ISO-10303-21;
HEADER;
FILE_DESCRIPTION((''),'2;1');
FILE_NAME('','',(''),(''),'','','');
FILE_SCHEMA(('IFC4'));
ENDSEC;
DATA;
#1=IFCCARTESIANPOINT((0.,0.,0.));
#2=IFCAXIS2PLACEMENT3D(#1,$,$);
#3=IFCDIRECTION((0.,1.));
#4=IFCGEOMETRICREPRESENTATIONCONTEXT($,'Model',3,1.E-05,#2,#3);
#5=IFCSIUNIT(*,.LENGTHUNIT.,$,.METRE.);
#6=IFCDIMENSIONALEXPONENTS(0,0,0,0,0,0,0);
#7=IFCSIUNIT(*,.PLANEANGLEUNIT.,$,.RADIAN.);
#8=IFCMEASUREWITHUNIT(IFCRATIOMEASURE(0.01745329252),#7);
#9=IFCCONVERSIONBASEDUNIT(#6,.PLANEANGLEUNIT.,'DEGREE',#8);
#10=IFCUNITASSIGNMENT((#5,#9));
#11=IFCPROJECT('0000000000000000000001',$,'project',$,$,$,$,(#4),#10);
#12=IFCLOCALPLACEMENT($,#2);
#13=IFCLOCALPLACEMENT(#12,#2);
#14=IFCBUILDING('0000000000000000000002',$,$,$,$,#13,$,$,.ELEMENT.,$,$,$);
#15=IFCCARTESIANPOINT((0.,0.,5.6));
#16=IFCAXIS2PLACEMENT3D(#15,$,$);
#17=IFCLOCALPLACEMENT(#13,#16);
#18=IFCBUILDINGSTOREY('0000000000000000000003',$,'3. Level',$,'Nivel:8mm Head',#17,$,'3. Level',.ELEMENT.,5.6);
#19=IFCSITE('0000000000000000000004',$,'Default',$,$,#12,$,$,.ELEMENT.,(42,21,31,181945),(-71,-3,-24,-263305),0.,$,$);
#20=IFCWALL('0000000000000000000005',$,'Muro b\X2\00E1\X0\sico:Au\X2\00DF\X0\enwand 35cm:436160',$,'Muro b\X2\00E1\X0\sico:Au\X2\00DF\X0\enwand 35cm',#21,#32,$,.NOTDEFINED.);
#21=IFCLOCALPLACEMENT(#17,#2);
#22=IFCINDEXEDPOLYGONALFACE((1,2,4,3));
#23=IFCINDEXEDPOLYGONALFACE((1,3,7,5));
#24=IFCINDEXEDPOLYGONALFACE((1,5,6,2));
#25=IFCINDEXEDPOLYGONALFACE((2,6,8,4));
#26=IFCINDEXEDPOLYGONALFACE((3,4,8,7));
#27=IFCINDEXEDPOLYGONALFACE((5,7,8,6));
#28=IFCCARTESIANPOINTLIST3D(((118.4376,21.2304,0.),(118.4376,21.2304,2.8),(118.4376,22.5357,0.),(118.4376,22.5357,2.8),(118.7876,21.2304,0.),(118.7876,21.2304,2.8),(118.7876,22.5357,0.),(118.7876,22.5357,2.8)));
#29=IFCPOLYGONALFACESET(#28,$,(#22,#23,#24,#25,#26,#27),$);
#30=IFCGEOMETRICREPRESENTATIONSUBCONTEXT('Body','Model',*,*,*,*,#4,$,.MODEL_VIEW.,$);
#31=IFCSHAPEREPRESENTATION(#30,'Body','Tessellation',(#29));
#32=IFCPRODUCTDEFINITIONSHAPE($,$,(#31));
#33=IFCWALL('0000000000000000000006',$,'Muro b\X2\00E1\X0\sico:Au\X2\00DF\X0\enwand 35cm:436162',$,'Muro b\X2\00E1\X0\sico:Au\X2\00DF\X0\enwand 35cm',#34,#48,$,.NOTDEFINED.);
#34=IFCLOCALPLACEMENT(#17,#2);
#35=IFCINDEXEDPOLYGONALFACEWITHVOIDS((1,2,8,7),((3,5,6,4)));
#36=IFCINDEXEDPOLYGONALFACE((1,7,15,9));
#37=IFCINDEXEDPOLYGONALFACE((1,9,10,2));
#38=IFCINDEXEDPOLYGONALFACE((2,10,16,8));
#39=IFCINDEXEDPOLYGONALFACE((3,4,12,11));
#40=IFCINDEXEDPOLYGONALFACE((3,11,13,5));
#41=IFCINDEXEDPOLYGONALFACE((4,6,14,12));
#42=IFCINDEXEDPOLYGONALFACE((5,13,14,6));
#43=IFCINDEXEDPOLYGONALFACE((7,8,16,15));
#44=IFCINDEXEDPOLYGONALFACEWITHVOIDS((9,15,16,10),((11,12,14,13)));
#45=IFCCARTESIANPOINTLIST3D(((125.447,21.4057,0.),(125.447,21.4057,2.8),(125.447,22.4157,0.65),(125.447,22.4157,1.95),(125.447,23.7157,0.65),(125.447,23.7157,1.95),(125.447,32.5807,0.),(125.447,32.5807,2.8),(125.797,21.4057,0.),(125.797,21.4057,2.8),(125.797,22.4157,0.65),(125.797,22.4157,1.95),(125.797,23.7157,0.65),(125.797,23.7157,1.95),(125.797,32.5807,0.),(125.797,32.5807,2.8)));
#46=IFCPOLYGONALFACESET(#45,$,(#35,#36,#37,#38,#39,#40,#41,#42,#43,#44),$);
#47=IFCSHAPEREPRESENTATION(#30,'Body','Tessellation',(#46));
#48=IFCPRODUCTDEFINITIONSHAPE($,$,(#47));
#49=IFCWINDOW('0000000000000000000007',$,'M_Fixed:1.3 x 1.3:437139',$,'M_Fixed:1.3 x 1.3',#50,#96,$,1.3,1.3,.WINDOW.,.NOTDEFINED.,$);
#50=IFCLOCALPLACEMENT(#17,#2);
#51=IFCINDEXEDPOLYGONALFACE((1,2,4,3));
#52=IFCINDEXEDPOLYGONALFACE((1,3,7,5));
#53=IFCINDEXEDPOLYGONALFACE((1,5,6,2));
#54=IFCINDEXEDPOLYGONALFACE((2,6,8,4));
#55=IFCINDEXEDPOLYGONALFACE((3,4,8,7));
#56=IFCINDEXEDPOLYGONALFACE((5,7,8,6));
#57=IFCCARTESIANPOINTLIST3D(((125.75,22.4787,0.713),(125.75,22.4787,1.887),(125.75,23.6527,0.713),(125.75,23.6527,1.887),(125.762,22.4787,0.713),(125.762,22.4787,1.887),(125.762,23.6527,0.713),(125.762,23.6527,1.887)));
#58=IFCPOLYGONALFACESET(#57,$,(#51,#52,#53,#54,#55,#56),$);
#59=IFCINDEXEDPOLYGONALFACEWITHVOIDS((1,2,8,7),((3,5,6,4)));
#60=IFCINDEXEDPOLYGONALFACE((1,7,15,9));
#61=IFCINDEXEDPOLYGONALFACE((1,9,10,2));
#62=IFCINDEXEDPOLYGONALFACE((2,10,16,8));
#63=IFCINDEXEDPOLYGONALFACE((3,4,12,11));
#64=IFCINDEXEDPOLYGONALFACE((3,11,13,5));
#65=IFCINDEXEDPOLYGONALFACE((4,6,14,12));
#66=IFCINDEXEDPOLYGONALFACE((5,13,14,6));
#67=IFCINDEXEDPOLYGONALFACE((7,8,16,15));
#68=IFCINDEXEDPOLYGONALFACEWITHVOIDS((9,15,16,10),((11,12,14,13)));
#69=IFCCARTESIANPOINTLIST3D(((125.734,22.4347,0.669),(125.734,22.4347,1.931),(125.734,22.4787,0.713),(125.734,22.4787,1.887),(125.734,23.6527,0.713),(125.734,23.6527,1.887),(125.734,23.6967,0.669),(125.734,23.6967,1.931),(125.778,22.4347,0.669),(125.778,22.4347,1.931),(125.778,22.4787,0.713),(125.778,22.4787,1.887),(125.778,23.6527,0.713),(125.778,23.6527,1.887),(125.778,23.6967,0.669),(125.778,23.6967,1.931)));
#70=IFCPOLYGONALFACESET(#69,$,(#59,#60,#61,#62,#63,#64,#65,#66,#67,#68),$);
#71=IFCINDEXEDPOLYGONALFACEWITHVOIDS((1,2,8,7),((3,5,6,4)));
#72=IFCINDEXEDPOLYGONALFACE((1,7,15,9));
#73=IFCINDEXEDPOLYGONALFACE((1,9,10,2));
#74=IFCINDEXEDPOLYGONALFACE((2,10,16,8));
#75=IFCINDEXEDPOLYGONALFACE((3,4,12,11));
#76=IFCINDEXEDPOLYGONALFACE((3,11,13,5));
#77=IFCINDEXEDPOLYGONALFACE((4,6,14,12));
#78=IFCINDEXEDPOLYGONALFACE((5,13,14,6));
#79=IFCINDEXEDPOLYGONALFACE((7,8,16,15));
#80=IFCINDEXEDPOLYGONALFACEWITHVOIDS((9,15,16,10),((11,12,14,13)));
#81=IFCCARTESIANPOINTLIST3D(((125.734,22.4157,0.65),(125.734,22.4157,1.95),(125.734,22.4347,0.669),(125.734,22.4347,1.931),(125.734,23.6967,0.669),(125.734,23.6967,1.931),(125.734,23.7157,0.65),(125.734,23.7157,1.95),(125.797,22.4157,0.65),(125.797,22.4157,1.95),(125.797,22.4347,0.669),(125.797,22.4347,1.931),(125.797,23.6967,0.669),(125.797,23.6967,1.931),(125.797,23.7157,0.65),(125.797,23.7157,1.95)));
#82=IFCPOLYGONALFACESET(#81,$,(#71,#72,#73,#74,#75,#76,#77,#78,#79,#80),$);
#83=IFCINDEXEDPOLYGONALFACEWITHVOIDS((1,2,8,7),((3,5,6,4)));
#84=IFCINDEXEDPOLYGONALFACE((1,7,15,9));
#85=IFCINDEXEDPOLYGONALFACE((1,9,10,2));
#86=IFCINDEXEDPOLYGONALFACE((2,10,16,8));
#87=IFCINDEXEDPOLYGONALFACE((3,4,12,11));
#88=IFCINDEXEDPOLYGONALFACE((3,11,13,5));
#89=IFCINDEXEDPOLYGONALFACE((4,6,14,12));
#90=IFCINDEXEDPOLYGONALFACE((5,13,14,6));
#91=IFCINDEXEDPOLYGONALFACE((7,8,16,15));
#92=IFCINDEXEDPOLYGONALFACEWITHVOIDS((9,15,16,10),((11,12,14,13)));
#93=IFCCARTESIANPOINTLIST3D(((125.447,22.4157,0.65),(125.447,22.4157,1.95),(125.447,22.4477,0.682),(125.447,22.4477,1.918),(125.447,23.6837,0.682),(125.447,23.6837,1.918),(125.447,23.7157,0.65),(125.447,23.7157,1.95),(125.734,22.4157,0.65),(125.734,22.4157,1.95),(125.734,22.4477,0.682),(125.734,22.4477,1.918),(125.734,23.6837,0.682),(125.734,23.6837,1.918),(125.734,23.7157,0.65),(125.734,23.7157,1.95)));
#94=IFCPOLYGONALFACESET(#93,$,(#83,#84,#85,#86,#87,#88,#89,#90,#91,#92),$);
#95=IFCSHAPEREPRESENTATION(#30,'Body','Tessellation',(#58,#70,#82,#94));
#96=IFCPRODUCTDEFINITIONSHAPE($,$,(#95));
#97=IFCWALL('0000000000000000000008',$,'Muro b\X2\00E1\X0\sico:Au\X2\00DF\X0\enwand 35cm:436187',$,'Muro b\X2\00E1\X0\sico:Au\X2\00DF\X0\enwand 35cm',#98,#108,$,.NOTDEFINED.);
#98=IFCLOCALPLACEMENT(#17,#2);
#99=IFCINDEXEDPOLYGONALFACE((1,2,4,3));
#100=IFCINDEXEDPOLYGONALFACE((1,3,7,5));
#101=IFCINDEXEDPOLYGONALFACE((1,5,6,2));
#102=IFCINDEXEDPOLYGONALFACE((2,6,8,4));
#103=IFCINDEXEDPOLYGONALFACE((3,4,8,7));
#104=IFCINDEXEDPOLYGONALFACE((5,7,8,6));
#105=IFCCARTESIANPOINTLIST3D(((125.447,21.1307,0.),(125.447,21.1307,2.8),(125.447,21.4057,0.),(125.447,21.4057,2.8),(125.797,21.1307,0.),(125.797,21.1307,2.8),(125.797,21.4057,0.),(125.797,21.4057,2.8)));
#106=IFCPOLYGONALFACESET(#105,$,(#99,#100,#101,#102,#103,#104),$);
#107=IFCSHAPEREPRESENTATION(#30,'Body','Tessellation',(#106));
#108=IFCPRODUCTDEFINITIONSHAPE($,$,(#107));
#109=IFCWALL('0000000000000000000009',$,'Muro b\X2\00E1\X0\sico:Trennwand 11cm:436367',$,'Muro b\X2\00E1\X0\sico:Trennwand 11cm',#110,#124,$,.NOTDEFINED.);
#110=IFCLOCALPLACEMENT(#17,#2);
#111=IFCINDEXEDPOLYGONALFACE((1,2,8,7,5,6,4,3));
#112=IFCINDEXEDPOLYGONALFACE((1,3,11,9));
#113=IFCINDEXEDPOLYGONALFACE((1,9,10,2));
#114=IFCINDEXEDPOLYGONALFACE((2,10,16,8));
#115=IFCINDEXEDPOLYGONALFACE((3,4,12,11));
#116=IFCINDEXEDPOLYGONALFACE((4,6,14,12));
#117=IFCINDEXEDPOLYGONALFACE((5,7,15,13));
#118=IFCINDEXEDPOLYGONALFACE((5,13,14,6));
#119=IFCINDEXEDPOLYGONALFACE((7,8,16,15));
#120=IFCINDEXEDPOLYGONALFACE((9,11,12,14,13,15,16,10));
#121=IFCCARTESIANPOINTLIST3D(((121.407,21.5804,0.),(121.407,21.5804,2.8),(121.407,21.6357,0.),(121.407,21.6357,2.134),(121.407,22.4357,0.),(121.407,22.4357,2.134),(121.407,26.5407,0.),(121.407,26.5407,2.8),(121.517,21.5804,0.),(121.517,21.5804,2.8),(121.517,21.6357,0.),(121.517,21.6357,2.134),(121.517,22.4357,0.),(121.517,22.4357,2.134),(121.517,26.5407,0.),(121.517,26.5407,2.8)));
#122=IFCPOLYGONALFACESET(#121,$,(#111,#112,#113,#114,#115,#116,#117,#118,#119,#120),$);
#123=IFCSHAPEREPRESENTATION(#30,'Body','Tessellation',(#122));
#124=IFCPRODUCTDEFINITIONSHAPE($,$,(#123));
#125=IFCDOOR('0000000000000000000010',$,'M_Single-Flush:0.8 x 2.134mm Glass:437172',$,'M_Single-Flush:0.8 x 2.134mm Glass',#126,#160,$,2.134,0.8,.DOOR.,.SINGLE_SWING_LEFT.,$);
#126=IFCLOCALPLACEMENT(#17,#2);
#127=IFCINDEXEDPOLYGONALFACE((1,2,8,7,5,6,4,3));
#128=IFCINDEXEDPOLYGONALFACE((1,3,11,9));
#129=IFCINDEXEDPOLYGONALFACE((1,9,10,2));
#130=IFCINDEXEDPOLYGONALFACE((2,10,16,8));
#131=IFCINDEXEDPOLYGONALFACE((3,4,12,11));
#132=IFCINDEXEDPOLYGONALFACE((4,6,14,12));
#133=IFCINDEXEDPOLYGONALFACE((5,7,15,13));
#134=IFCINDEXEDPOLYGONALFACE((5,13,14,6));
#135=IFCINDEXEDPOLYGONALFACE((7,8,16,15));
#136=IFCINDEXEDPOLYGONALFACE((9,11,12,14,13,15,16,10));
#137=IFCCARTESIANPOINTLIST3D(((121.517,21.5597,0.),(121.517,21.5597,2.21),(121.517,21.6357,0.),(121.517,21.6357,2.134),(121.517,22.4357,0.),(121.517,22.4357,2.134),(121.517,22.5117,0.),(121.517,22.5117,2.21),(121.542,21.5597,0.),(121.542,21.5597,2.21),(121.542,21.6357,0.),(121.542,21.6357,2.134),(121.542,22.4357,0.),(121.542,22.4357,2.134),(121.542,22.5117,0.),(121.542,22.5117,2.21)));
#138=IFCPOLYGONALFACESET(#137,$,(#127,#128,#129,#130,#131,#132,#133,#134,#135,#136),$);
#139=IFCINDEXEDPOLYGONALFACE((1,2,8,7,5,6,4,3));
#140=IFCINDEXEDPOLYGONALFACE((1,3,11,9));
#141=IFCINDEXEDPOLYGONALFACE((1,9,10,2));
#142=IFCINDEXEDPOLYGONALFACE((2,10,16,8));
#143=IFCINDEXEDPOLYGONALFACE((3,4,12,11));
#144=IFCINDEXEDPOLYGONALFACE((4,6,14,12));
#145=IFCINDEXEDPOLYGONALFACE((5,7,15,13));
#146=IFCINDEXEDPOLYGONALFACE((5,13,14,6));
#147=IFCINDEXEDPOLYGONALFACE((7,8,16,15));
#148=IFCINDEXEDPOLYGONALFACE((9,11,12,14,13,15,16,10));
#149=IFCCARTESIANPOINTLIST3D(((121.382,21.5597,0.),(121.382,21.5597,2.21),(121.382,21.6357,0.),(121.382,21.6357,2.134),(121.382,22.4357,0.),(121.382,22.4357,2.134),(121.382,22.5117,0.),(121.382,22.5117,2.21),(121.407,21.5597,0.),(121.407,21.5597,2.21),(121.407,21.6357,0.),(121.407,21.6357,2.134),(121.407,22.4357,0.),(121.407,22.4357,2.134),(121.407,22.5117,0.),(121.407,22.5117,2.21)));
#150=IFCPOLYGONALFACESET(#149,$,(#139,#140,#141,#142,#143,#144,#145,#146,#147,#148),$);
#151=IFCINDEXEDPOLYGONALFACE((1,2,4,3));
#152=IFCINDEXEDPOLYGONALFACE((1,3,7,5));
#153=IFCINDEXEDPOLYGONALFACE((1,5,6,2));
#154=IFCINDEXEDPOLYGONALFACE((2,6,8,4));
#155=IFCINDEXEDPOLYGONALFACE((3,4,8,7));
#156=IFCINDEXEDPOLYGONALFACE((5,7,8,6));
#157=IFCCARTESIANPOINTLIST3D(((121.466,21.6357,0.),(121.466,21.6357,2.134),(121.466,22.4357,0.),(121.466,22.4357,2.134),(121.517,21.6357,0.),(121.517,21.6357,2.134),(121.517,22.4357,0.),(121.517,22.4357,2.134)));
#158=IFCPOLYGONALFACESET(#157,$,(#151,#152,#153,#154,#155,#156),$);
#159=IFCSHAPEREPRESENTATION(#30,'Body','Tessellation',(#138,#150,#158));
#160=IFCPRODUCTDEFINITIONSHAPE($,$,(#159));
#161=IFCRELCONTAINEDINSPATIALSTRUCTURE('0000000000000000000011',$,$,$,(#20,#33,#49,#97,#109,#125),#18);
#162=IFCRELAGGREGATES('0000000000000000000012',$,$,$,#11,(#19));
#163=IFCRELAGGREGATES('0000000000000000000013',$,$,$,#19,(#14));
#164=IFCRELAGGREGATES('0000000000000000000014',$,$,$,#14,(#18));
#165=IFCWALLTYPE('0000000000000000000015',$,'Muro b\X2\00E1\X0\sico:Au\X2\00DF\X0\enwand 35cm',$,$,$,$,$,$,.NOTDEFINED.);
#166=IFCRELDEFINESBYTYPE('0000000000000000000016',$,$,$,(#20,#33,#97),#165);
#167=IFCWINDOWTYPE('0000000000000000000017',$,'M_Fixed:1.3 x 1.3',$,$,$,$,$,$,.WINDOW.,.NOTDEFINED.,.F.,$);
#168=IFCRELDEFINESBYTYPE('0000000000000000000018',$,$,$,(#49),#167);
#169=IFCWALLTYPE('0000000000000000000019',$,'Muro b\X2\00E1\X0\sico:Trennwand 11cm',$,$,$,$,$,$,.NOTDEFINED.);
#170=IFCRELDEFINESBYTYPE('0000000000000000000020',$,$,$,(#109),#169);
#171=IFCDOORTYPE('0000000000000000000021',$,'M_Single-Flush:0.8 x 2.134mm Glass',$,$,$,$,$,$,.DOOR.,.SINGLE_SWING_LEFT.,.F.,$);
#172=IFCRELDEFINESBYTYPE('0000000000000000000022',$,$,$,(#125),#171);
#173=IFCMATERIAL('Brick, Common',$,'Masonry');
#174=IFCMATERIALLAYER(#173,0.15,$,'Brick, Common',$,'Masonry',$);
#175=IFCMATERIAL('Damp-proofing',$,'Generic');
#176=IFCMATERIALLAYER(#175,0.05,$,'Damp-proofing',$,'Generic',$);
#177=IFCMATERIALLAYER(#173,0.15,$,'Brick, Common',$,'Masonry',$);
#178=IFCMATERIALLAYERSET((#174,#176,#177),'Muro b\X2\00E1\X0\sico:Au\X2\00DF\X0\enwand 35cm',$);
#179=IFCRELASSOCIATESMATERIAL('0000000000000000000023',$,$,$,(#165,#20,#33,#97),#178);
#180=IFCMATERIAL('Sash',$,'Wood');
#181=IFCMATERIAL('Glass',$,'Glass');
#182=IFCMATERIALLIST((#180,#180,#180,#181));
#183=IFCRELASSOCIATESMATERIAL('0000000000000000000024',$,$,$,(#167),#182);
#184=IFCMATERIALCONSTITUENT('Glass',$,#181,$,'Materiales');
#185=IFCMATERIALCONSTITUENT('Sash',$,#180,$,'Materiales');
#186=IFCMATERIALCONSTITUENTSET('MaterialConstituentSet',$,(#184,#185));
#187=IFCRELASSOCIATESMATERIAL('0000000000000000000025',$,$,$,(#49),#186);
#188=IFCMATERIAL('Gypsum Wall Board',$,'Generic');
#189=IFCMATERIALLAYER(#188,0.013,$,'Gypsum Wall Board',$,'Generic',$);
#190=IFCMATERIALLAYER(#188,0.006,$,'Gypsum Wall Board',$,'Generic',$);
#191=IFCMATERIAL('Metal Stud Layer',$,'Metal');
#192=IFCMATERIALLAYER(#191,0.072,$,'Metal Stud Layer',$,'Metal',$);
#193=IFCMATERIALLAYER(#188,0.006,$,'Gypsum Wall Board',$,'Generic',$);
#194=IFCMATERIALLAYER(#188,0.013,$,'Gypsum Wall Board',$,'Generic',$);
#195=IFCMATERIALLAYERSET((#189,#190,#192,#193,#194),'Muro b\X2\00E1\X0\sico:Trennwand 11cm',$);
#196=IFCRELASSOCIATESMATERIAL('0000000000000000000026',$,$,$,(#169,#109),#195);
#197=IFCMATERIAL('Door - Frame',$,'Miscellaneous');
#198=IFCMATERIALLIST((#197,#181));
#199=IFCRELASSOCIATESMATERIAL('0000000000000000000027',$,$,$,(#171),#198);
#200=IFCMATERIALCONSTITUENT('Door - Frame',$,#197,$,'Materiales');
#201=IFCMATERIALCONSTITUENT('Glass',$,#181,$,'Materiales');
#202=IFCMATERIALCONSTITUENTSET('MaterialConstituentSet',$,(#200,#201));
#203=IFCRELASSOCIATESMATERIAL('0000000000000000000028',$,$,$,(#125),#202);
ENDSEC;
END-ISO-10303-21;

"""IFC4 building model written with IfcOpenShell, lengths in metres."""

from ifc_helpers import new_model, entity, si_unit, converted_unit, direction, frame, frame_2d, origin, origin_2d_with_axis, place, context, subcontext, project, spatial, polyline, rectangle, outline, extrude, source, transform, mapped, material, material_list, layer, layer_set, layer_usage, constituent, constituent_set, type_object, type_shapes, element, fill, save


model = new_model("IFC4")

# Units and contexts
model_context = context("Model", 3, precision=1e-05, world=origin(), true_north=direction((0.0, 1.0)))
body_context = subcontext(model_context, "Body", "Model", "MODEL_VIEW")
ifc_project = project(units=[si_unit("LENGTHUNIT", "METRE"), converted_unit("PLANEANGLEUNIT", "DEGREE", entity("IfcRatioMeasure", 0.01745329252), si_unit("PLANEANGLEUNIT", "RADIAN"), dimensions=[0, 0, 0, 0, 0, 0, 0])], contexts=[model_context])

# Site, building, storey
site_placement = place(None, origin())
site = spatial("IfcSite", under=ifc_project, at=site_placement, Name="Default", CompositionType="ELEMENT", RefLatitude=(42, 21, 31, 181945), RefLongitude=(-71, -3, -24, -263305), RefElevation=0.0)
building_placement = place(site_placement, origin())
building = spatial("IfcBuilding", under=site, at=building_placement, CompositionType="ELEMENT")
storey_placement = place(building_placement, frame((0.0, 0.0, 5.6)))
storey = spatial("IfcBuildingStorey", under=building, at=storey_placement, Name="3. Level", ObjectType="Nivel:8mm Head", LongName="3. Level", CompositionType="ELEMENT", Elevation=5.6)

# Wall
ifc_material_1 = material(Name="Brick, Common", Category="Masonry")
ifc_layer_1 = layer(ifc_material_1, 0.15, Name="Brick, Common", Category="Masonry")
ifc_material_2 = material(Name="Damp-proofing", Category="Generic")
ifc_layer_2 = layer(ifc_material_2, 0.05, Name="Damp-proofing", Category="Generic")
ifc_layer_3 = layer(ifc_material_1, 0.15, Name="Brick, Common", Category="Masonry")
ifc_layer_set_1 = layer_set([ifc_layer_1, ifc_layer_2, ifc_layer_3], Name="Muro básico:Außenwand 35cm")
ifc_layer_usage_1 = layer_usage(ifc_layer_set_1, "AXIS2", "NEGATIVE", 0.175)
wall_type_1 = type_object("IfcWallType", Name="Muro básico:Außenwand 35cm", PredefinedType="NOTDEFINED", material=ifc_layer_set_1)
wall_1_placement = place(storey_placement, frame((118.6126, 21.2304, 0.0), z_axis=(0.0, 0.0, 1.0), x_axis=(0.0, 1.0, 0.0)))
element("IfcWall", 1, at=wall_1_placement, inside=storey, type_object=wall_type_1, material=ifc_layer_usage_1, Name="Muro básico:Außenwand 35cm:436160", ObjectType="Muro básico:Außenwand 35cm", PredefinedType="NOTDEFINED", context=body_context, shape_type="SweptSolid", body=[
    extrude(rectangle(XDim=1.3053, YDim=0.35, at=frame_2d((0.6527, 0.0), x_axis=(-1.0, 0.0))), origin(), (0.0, 0.0, 1.0), 2.8),
])

# Wall, opening, window
ifc_layer_usage_2 = layer_usage(ifc_layer_set_1, "AXIS2", "NEGATIVE", 0.175)
wall_2_placement = place(storey_placement, frame((125.622, 21.4057, 0.0), z_axis=(0.0, 0.0, 1.0), x_axis=(0.0, 1.0, 0.0)))
wall_2 = element("IfcWall", 2, at=wall_2_placement, inside=storey, type_object=wall_type_1, material=ifc_layer_usage_2, Name="Muro básico:Außenwand 35cm:436162", ObjectType="Muro básico:Außenwand 35cm", PredefinedType="NOTDEFINED", context=body_context, shape_type="SweptSolid", body=[
    extrude(rectangle(XDim=11.175, YDim=0.35, at=frame_2d((5.5875, 0.0), x_axis=(-1.0, 0.0))), origin(), (0.0, 0.0, 1.0), 2.8),
])
opening_1_placement = place(wall_2_placement, frame((2.31, 0.175, 0.65)))
opening_1 = element("IfcOpeningElement", 3, at=opening_1_placement, cuts=wall_2, ObjectType="Opening", PredefinedType="OPENING", context=body_context, shape_type="SweptSolid", body=[
    extrude(rectangle(XDim=1.3, YDim=1.3, at=frame_2d((0.65, 0.65), x_axis=(1.0, 0.0))), frame((0.0, 0.0, 0.0), z_axis=(0.0, -1.0, 0.0), x_axis=(0.0, 0.0, 1.0)), (0.0, 0.0, 1.0), 0.35),
])
ifc_material_3 = material(Name="Glass", Category="Glass")
ifc_constituent_1 = constituent(ifc_material_3, Name="Glass", Category="Materiales")
ifc_material_4 = material(Name="Sash", Category="Wood")
ifc_constituent_2 = constituent(ifc_material_4, Name="Sash", Category="Materiales")
ifc_constituent_set_1 = constituent_set(constituents=[ifc_constituent_1, ifc_constituent_2], Name="MaterialConstituentSet")
ifc_material_list_1 = material_list([ifc_material_4, ifc_material_4, ifc_material_4, ifc_material_3])
window_type = type_object("IfcWindowType", Name="M_Fixed:1.3 x 1.3", ParameterTakesPrecedence=False, PartitioningType="NOTDEFINED", PredefinedType="WINDOW", material=ifc_material_list_1)
shared_shape_1 = source(origin(), body_context, "Body", "SweptSolid", [
    extrude(rectangle(XDim=0.012, YDim=1.174, at=origin_2d_with_axis()), frame((0.65, 0.309, 0.063), z_axis=(0.0, 0.0, 1.0), x_axis=(0.0, -1.0, 0.0)), (0.0, 0.0, 1.0), 1.174),
    extrude(outline(polyline([(-0.631, -0.631), (0.631, -0.631), (0.631, 0.631), (-0.631, 0.631), (-0.631, -0.631)]), holes=[polyline([(-0.587, -0.587), (-0.587, 0.587), (0.587, 0.587), (0.587, -0.587), (-0.587, -0.587)])]), frame((0.65, 0.287, 0.65), z_axis=(0.0, 1.0, 0.0), x_axis=(1.0, 0.0, 0.0)), (0.0, 0.0, 1.0), 0.044),
    extrude(outline(polyline([(-0.65, -0.65), (0.65, -0.65), (0.65, 0.65), (-0.65, 0.65), (-0.65, -0.65)]), holes=[polyline([(-0.631, -0.631), (-0.631, 0.631), (0.631, 0.631), (0.631, -0.631), (-0.631, -0.631)])]), frame((0.65, 0.287, 0.65), z_axis=(0.0, 1.0, 0.0), x_axis=(1.0, 0.0, 0.0)), (0.0, 0.0, 1.0), 0.063),
    extrude(outline(polyline([(-0.65, -0.65), (0.65, -0.65), (0.65, 0.65), (-0.65, 0.65), (-0.65, -0.65)]), holes=[polyline([(-0.618, -0.618), (-0.618, 0.618), (0.618, 0.618), (0.618, -0.618), (-0.618, -0.618)])]), frame((0.65, 0.0, 0.65), z_axis=(0.0, 1.0, 0.0), x_axis=(1.0, 0.0, 0.0)), (0.0, 0.0, 1.0), 0.287),
])
type_shapes(window_type, [shared_shape_1])
window_placement = place(opening_1_placement, frame((0.0, 0.0, 0.0), z_axis=(0.0, 0.0, 1.0), x_axis=(-1.0, 0.0, 0.0)))
window = element("IfcWindow", 4, at=window_placement, inside=storey, type_object=window_type, material=ifc_constituent_set_1, Name="M_Fixed:1.3 x 1.3:437139", ObjectType="M_Fixed:1.3 x 1.3", OverallHeight=1.3, OverallWidth=1.3, PartitioningType="NOTDEFINED", PredefinedType="WINDOW", context=body_context, shape_type="MappedRepresentation", body=[
    mapped(shared_shape_1, transform((0.0, 0.0, 0.0), scale=1.0)),
])
fill(opening_1, window)

# Wall
ifc_layer_usage_3 = layer_usage(ifc_layer_set_1, "AXIS2", "NEGATIVE", 0.175)
wall_3_placement = place(storey_placement, frame((125.622, 21.4057, 0.0), z_axis=(0.0, 0.0, 1.0), x_axis=(0.0, -1.0, 0.0)))
element("IfcWall", 5, at=wall_3_placement, inside=storey, type_object=wall_type_1, material=ifc_layer_usage_3, Name="Muro básico:Außenwand 35cm:436187", ObjectType="Muro básico:Außenwand 35cm", PredefinedType="NOTDEFINED", context=body_context, shape_type="SweptSolid", body=[
    extrude(rectangle(XDim=0.275, YDim=0.35, at=frame_2d((0.1375, 0.0), x_axis=(-1.0, 0.0))), origin(), (0.0, 0.0, 1.0), 2.8),
])

# Wall, opening, door
ifc_material_5 = material(Name="Gypsum Wall Board", Category="Generic")
ifc_layer_4 = layer(ifc_material_5, 0.013, Name="Gypsum Wall Board", Category="Generic")
ifc_layer_5 = layer(ifc_material_5, 0.006, Name="Gypsum Wall Board", Category="Generic")
ifc_material_6 = material(Name="Metal Stud Layer", Category="Metal")
ifc_layer_6 = layer(ifc_material_6, 0.072, Name="Metal Stud Layer", Category="Metal")
ifc_layer_7 = layer(ifc_material_5, 0.006, Name="Gypsum Wall Board", Category="Generic")
ifc_layer_8 = layer(ifc_material_5, 0.013, Name="Gypsum Wall Board", Category="Generic")
ifc_layer_set_2 = layer_set([ifc_layer_4, ifc_layer_5, ifc_layer_6, ifc_layer_7, ifc_layer_8], Name="Muro básico:Trennwand 11cm")
ifc_layer_usage_4 = layer_usage(ifc_layer_set_2, "AXIS2", "NEGATIVE", 0.055)
wall_type_2 = type_object("IfcWallType", Name="Muro básico:Trennwand 11cm", PredefinedType="NOTDEFINED", material=ifc_layer_set_2)
wall_4_placement = place(storey_placement, frame((121.462, 26.5407, 0.0), z_axis=(0.0, 0.0, 1.0), x_axis=(0.0, -1.0, 0.0)))
wall_4 = element("IfcWall", 6, at=wall_4_placement, inside=storey, type_object=wall_type_2, material=ifc_layer_usage_4, Name="Muro básico:Trennwand 11cm:436367", ObjectType="Muro básico:Trennwand 11cm", PredefinedType="NOTDEFINED", context=body_context, shape_type="SweptSolid", body=[
    extrude(rectangle(XDim=4.9603, YDim=0.11, at=frame_2d((2.4802, 0.0), x_axis=(-1.0, 0.0))), origin(), (0.0, 0.0, 1.0), 2.8),
])
opening_2_placement = place(wall_4_placement, frame((4.105, -0.055, 0.0)))
opening_2 = element("IfcOpeningElement", 7, at=opening_2_placement, cuts=wall_4, ObjectType="Opening", PredefinedType="OPENING", context=body_context, shape_type="SweptSolid", body=[
    extrude(rectangle(XDim=0.8, YDim=2.134, at=frame_2d((1.067, 0.4), x_axis=(0.0, -1.0))), frame((0.0, 0.0, 0.0), z_axis=(0.0, 1.0, 0.0), x_axis=(0.0, 0.0, 1.0)), (0.0, 0.0, 1.0), 0.11),
])
ifc_material_7 = material(Name="Door - Frame", Category="Miscellaneous")
ifc_constituent_3 = constituent(ifc_material_7, Name="Door - Frame", Category="Materiales")
ifc_constituent_4 = constituent(ifc_material_3, Name="Glass", Category="Materiales")
ifc_constituent_set_2 = constituent_set(constituents=[ifc_constituent_3, ifc_constituent_4], Name="MaterialConstituentSet")
ifc_material_list_2 = material_list([ifc_material_7, ifc_material_3])
door_type_1 = type_object("IfcDoorType", Name="M_Single-Flush:0.8 x 2.134mm Glass", OperationType="SINGLE_SWING_LEFT", ParameterTakesPrecedence=False, PredefinedType="DOOR", material=ifc_material_list_2)
shared_shape_2 = source(origin(), body_context, "Body", "SweptSolid", [
    extrude(outline(polyline([(-0.476, -1.124), (0.476, -1.124), (0.476, 1.086), (0.4, 1.086), (0.4, -1.048), (-0.4, -1.048), (-0.4, 1.086), (-0.476, 1.086), (-0.476, -1.124)])), frame((0.4, 0.135, 1.086), z_axis=(0.0, -1.0, 0.0), x_axis=(-1.0, 0.0, 0.0)), (0.0, 0.0, 1.0), 0.025),
    extrude(outline(polyline([(-1.124, -0.476), (1.086, -0.476), (1.086, -0.4), (-1.048, -0.4), (-1.048, 0.4), (1.086, 0.4), (1.086, 0.476), (-1.124, 0.476), (-1.124, -0.476)])), frame((0.4, 0.0, 1.086), z_axis=(0.0, -1.0, 0.0), x_axis=(0.0, 0.0, -1.0)), (0.0, 0.0, 1.0), 0.025),
    extrude(rectangle(XDim=0.8, YDim=0.051, at=origin_2d_with_axis()), frame((0.4, 0.0845, 0.0)), (0.0, 0.0, 1.0), 2.134),
])
type_shapes(door_type_1, [shared_shape_2])
door_1_placement = place(opening_2_placement, origin())
door_1 = element("IfcDoor", 8, at=door_1_placement, inside=storey, type_object=door_type_1, material=ifc_constituent_set_2, Name="M_Single-Flush:0.8 x 2.134mm Glass:437172", ObjectType="M_Single-Flush:0.8 x 2.134mm Glass", OperationType="SINGLE_SWING_LEFT", OverallHeight=2.134, OverallWidth=0.8, PredefinedType="DOOR", context=body_context, shape_type="MappedRepresentation", body=[
    mapped(shared_shape_2, transform((0.0, 0.0, 0.0), scale=1.0)),
])
fill(opening_2, door_1)

save(model, "model.ifc")
